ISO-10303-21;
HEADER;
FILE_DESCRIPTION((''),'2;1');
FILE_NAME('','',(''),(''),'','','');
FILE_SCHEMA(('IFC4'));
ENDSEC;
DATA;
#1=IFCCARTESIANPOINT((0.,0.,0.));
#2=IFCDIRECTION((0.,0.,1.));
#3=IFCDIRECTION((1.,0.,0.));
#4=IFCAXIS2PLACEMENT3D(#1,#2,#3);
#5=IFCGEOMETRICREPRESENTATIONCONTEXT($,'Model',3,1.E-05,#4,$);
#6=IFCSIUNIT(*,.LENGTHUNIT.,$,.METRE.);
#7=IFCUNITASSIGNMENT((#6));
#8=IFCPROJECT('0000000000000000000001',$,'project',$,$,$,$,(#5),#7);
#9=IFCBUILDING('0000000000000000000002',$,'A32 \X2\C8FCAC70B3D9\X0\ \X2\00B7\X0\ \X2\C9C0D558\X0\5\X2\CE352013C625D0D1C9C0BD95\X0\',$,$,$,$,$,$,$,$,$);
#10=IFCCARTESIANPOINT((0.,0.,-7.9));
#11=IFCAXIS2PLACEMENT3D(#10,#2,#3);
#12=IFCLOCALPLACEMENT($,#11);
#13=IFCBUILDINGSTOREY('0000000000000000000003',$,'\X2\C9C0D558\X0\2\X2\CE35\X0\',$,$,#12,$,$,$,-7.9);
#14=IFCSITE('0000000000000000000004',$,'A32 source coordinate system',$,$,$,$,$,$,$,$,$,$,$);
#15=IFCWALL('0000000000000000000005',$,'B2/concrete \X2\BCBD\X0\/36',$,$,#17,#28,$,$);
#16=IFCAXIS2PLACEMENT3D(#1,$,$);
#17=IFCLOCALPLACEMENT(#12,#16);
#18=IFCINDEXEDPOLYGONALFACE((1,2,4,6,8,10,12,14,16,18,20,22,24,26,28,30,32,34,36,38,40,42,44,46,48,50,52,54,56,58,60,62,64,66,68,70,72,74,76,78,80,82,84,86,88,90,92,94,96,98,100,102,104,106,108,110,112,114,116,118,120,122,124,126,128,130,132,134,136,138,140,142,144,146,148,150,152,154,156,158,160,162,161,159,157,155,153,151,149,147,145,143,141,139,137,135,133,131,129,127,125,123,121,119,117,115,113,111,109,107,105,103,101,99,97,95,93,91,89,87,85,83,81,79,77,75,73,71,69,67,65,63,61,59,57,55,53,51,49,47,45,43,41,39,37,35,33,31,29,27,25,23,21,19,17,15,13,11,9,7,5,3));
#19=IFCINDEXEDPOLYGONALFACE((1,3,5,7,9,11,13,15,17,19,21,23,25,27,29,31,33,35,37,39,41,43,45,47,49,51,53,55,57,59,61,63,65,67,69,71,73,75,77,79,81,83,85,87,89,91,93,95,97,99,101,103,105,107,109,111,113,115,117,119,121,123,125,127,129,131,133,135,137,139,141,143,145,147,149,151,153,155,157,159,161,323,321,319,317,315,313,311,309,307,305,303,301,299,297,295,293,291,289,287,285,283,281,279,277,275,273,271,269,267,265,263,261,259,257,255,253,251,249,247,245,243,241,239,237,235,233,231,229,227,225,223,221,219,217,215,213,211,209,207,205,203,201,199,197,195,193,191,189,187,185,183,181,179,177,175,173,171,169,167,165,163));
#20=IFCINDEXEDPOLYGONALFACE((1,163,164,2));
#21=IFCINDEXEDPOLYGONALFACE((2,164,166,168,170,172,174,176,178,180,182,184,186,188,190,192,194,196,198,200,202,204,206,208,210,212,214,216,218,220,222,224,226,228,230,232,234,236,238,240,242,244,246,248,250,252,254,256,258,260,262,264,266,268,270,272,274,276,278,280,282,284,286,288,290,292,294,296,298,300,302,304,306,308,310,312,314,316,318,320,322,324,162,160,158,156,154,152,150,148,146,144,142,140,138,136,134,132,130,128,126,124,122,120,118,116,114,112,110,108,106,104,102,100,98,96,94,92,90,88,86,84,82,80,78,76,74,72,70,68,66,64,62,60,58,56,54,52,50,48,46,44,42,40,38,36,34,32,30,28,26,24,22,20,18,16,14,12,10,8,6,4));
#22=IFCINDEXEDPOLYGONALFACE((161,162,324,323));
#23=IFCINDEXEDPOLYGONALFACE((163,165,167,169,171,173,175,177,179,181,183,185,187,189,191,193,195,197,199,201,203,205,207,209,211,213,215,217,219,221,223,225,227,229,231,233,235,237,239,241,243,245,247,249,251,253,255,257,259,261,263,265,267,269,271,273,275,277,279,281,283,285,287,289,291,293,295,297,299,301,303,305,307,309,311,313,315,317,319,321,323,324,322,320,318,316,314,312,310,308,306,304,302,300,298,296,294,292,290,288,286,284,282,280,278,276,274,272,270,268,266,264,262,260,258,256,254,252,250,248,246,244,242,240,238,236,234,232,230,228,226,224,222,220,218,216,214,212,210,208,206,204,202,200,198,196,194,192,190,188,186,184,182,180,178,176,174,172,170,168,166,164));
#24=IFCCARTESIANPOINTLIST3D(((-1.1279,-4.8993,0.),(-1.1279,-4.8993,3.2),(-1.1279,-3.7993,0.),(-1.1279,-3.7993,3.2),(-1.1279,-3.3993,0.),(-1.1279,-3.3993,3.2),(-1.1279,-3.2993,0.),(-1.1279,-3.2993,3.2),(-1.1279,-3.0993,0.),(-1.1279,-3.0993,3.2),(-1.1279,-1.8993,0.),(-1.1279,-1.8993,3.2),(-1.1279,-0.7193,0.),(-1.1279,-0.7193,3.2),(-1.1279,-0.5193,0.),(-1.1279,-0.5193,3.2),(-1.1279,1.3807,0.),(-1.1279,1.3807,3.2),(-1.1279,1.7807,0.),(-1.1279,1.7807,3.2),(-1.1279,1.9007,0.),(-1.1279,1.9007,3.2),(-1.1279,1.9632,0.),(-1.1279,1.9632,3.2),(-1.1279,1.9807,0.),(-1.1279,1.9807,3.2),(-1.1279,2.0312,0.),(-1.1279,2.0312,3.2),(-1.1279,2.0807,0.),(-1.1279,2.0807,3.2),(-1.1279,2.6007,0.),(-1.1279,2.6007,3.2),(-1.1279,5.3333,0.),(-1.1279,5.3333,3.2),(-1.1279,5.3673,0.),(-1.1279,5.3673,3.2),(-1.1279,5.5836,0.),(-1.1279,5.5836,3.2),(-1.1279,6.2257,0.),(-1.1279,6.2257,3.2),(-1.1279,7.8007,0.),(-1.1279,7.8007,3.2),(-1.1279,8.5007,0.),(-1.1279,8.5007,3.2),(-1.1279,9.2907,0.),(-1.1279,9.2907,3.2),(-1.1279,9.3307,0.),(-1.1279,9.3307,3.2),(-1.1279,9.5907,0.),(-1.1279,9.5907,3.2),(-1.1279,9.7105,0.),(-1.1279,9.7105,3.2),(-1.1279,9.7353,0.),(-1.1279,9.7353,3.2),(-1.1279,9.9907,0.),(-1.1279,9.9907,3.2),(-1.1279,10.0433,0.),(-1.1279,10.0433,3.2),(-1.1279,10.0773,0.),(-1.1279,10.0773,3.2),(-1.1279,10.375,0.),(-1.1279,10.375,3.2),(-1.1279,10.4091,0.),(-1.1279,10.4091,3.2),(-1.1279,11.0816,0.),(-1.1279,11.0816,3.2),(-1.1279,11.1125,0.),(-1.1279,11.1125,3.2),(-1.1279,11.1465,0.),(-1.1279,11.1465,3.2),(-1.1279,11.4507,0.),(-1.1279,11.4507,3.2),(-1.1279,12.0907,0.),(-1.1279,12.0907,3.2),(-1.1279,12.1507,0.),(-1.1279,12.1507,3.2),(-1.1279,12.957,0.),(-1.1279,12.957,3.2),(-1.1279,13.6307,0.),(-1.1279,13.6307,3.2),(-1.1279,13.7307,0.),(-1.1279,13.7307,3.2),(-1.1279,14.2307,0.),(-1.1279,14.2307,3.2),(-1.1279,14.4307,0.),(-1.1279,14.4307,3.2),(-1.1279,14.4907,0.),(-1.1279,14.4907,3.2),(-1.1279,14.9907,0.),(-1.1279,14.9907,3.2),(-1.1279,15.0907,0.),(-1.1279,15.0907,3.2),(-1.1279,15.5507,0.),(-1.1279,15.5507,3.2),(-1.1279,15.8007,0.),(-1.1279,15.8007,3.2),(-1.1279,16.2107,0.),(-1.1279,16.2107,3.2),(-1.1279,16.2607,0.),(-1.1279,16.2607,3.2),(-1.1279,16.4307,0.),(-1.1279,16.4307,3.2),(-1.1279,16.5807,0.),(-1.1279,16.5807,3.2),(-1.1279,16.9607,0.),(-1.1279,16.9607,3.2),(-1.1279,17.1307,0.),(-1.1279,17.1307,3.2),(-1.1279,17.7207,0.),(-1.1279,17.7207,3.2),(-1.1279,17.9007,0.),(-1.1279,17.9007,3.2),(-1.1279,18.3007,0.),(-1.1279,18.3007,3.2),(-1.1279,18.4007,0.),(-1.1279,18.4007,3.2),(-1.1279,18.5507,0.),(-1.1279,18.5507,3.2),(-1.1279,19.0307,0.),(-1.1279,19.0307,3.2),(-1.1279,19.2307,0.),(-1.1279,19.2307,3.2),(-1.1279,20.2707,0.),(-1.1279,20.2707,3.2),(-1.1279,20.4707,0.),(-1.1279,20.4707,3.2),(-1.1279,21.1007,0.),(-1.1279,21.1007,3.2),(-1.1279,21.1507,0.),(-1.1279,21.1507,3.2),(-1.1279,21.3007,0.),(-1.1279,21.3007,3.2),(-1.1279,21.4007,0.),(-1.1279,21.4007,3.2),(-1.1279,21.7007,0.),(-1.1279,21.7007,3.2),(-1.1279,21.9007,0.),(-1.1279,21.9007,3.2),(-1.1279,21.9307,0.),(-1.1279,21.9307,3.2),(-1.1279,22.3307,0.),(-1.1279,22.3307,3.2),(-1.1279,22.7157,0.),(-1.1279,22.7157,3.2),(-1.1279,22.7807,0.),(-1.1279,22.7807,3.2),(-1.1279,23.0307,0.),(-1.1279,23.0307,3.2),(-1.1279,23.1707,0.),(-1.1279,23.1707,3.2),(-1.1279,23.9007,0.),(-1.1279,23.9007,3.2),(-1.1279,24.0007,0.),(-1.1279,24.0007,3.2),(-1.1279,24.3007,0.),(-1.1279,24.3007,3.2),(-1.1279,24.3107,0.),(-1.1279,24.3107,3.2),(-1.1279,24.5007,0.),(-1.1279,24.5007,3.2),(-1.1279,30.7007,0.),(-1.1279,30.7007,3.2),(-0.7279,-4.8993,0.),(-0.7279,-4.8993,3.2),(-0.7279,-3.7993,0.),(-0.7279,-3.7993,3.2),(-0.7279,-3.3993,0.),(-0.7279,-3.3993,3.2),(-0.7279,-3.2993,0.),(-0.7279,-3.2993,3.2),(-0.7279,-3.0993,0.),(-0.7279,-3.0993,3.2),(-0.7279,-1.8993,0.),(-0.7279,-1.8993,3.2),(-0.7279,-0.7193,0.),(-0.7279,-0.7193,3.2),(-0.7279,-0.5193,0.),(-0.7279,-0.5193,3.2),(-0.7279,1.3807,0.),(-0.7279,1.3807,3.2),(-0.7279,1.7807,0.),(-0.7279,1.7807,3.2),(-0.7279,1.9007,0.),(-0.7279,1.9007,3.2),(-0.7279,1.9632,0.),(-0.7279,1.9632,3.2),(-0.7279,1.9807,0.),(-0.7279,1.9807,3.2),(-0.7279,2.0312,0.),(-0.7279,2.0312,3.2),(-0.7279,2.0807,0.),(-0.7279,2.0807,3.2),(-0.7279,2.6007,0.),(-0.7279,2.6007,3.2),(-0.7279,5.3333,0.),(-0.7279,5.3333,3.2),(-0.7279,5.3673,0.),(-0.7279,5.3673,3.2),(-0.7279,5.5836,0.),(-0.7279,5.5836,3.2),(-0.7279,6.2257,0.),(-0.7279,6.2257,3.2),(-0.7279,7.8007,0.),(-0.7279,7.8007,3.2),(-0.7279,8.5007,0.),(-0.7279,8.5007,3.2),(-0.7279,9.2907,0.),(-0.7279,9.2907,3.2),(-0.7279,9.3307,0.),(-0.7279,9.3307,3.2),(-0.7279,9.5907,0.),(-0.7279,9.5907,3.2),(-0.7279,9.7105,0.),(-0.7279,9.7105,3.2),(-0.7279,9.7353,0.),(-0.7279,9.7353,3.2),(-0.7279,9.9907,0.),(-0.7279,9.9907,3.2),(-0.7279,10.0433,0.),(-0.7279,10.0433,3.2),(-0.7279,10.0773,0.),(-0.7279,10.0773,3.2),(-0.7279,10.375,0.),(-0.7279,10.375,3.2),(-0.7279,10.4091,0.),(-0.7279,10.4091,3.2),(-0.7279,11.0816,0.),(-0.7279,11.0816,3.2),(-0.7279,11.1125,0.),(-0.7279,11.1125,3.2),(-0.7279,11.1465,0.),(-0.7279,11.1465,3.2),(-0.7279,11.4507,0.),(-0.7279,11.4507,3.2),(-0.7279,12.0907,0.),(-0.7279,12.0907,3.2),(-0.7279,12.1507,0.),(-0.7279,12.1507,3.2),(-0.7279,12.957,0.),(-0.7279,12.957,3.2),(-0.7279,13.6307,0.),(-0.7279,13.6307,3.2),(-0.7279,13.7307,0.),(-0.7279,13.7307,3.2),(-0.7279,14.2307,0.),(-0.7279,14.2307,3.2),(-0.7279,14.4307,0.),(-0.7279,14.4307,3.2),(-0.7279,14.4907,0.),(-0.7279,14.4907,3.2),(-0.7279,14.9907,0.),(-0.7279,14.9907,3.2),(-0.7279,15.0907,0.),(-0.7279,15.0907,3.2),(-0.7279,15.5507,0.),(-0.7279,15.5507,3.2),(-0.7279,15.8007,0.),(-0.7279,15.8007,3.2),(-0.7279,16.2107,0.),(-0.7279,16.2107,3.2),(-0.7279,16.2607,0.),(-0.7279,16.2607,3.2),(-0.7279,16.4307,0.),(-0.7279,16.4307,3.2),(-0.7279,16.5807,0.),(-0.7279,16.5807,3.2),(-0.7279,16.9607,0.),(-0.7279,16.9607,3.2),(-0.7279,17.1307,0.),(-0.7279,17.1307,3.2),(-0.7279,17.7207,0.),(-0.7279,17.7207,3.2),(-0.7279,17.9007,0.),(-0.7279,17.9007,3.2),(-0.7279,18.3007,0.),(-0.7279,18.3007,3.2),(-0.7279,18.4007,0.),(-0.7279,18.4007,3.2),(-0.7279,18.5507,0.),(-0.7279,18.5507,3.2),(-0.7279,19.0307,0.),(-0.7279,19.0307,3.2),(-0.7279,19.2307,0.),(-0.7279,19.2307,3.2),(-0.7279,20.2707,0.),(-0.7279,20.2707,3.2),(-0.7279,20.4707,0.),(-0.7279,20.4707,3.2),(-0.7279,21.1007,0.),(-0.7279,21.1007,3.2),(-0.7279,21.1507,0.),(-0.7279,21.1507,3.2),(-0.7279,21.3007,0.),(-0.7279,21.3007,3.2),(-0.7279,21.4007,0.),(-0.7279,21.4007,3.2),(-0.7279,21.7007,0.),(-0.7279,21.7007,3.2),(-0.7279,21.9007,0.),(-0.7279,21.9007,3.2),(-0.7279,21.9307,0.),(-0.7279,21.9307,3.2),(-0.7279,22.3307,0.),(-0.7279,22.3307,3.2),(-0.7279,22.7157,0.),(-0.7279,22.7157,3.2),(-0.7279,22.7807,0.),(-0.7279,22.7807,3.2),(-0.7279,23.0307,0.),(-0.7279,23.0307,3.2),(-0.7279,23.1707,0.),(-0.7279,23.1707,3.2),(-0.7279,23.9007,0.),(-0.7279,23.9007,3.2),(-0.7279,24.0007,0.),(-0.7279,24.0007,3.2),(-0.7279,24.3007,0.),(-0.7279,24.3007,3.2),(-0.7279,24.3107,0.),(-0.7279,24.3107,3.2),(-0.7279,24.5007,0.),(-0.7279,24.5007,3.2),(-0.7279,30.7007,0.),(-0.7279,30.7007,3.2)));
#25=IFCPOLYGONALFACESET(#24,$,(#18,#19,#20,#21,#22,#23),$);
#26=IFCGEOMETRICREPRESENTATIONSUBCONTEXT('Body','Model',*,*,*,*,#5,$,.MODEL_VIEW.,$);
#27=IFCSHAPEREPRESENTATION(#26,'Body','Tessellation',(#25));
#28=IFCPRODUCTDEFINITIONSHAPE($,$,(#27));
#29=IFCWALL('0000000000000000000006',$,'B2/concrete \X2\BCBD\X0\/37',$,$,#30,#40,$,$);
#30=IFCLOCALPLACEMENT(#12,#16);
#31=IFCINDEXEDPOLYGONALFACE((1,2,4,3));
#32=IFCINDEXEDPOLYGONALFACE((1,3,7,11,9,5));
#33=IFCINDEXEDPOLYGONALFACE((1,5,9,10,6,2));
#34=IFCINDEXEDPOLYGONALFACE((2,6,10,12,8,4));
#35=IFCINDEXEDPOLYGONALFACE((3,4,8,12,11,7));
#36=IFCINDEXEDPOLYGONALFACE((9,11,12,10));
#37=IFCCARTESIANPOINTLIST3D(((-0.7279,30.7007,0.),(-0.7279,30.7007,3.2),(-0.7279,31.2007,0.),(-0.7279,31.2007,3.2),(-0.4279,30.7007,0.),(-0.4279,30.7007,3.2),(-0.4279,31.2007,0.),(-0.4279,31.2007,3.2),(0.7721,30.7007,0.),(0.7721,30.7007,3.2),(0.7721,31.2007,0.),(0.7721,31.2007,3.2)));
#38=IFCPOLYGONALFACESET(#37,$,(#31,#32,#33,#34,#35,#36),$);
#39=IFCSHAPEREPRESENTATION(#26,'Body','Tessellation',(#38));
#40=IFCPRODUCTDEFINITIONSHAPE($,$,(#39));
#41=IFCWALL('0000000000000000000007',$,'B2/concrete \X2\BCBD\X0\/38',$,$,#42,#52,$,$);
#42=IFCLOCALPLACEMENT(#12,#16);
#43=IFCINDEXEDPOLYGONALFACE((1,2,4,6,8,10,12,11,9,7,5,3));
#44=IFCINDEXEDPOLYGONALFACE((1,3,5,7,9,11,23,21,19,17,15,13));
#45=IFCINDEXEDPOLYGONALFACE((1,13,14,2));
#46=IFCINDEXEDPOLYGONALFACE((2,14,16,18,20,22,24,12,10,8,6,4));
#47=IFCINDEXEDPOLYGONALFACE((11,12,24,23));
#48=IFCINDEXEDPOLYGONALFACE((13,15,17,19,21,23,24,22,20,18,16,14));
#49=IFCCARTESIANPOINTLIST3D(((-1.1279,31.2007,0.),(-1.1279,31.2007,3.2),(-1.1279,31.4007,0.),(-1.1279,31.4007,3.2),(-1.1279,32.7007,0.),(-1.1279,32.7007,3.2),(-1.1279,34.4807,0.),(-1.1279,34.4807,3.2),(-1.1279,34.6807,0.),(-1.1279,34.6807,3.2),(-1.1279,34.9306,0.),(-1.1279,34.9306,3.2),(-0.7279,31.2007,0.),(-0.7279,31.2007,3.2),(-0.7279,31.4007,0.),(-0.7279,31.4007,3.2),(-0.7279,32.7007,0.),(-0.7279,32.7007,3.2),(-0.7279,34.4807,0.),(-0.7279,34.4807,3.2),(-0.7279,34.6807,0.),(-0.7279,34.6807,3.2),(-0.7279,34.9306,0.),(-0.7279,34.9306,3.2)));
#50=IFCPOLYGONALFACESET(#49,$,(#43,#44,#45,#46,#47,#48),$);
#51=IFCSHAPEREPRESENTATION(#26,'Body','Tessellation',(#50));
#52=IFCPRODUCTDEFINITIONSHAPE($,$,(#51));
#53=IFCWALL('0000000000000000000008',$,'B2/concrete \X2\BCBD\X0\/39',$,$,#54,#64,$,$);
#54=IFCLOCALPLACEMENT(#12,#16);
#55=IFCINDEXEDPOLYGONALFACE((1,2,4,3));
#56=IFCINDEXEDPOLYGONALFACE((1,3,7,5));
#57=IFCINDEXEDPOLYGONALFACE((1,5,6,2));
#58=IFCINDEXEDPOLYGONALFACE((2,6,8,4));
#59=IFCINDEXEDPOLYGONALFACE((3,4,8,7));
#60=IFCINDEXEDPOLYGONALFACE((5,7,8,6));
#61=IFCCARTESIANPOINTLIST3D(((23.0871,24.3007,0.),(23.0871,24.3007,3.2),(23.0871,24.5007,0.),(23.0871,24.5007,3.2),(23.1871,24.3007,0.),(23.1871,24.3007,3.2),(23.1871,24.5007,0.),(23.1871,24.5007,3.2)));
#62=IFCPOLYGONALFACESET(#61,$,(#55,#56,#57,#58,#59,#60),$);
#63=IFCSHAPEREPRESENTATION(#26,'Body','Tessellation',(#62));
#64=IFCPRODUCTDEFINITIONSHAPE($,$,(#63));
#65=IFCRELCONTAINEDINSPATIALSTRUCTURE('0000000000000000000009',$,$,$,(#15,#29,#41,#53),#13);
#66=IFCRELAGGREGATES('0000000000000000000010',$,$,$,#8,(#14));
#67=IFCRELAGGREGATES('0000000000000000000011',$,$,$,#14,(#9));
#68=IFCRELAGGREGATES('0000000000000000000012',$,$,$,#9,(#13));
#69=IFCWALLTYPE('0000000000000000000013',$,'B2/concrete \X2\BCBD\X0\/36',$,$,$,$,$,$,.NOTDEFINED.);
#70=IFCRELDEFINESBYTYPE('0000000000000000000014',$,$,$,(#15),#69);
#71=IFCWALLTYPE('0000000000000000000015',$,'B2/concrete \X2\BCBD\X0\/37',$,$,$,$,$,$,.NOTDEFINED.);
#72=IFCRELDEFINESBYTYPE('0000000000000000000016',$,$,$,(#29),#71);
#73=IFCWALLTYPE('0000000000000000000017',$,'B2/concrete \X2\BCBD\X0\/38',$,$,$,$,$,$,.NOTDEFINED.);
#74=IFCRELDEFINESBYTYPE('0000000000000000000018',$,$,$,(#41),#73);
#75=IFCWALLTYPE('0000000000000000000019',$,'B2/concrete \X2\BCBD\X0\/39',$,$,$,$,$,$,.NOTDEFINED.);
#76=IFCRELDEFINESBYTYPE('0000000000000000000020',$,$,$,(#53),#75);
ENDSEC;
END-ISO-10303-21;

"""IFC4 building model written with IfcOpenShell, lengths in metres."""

from ifc_helpers import new_model, si_unit, frame, origin, origin_with_axes, place, context, subcontext, project, spatial, polyline, outline, extrude, source, transform, mapped, type_object, type_shapes, element, save


model = new_model("IFC4")

# Units and contexts
model_context = context("Model", 3, precision=1e-05, world=origin_with_axes())
body_context = subcontext(model_context, "Body", "Model", "MODEL_VIEW")
ifc_project = project(units=[si_unit("LENGTHUNIT", "METRE")], contexts=[model_context])

# Site, building, storey
site = spatial("IfcSite", under=ifc_project, Name="A32 source coordinate system")
building = spatial("IfcBuilding", under=site, Name="A32 주거동 · 지하5층–옥탑지붕")
storey_placement = place(None, frame((0.0, 0.0, -7.9), z_axis=(0.0, 0.0, 1.0), x_axis=(1.0, 0.0, 0.0)))
storey = spatial("IfcBuildingStorey", under=building, at=storey_placement, Name="지하2층", Elevation=-7.9)

# Walls
wall_type_1 = type_object("IfcWallType", Name="B2/concrete 벽/36", PredefinedType="NOTDEFINED")
shared_shape_1 = source(origin(), body_context, "Body", "SweptSolid", [
    extrude(outline(polyline([(-1.1279, -3.3993), (-1.1279, -3.2993), (-1.1279, -3.0993), (-1.1279, -1.8993), (-1.1279, -0.7193), (-1.1279, -0.5193), (-1.1279, 1.3807), (-1.1279, 1.7807), (-1.1279, 1.9007), (-1.1279, 1.9632), (-1.1279, 1.9807), (-1.1279, 2.0312), (-1.1279, 2.0807), (-1.1279, 2.6007), (-1.1279, 5.3333), (-1.1279, 5.3673), (-1.1279, 5.5836), (-1.1279, 6.2257), (-1.1279, 7.8007), (-1.1279, 8.5007), (-1.1279, 9.2907), (-1.1279, 9.3307), (-1.1279, 9.5907), (-1.1279, 9.7105), (-1.1279, 9.7353), (-1.1279, 9.9907), (-1.1279, 10.0433), (-1.1279, 10.0773), (-1.1279, 10.375), (-1.1279, 10.4091), (-1.1279, 11.0816), (-1.1279, 11.1125), (-1.1279, 11.1465), (-1.1279, 11.4507), (-1.1279, 12.0907), (-1.1279, 12.1507), (-1.1279, 12.957), (-1.1279, 13.6307), (-1.1279, 13.7307), (-1.1279, 14.2307), (-1.1279, 14.4307), (-1.1279, 14.4907), (-1.1279, 14.9907), (-1.1279, 15.0907), (-1.1279, 15.5507), (-1.1279, 15.8007), (-1.1279, 16.2107), (-1.1279, 16.2607), (-1.1279, 16.4307), (-1.1279, 16.5807), (-1.1279, 16.9607), (-1.1279, 17.1307), (-1.1279, 17.7207), (-1.1279, 17.9007), (-1.1279, 18.3007), (-1.1279, 18.4007), (-1.1279, 18.5507), (-1.1279, 19.0307), (-1.1279, 19.2307), (-1.1279, 20.2707), (-1.1279, 20.4707), (-1.1279, 21.1007), (-1.1279, 21.1507), (-1.1279, 21.3007), (-1.1279, 21.4007), (-1.1279, 21.7007), (-1.1279, 21.9007), (-1.1279, 21.9307), (-1.1279, 22.3307), (-1.1279, 22.7157), (-1.1279, 22.7807), (-1.1279, 23.0307), (-1.1279, 23.1707), (-1.1279, 23.9007), (-1.1279, 24.0007), (-1.1279, 24.3007), (-1.1279, 24.3107), (-1.1279, 24.5007), (-1.1279, 30.7007), (-0.7279, 30.7007), (-0.7279, 24.5007), (-0.7279, 24.3107), (-0.7279, 24.3007), (-0.7279, 24.0007), (-0.7279, 23.9007), (-0.7279, 23.1707), (-0.7279, 23.0307), (-0.7279, 22.7807), (-0.7279, 22.7157), (-0.7279, 22.3307), (-0.7279, 21.9307), (-0.7279, 21.9007), (-0.7279, 21.7007), (-0.7279, 21.4007), (-0.7279, 21.3007), (-0.7279, 21.1507), (-0.7279, 21.1007), (-0.7279, 20.4707), (-0.7279, 20.2707), (-0.7279, 19.2307), (-0.7279, 19.0307), (-0.7279, 18.5507), (-0.7279, 18.4007), (-0.7279, 18.3007), (-0.7279, 17.9007), (-0.7279, 17.7207), (-0.7279, 17.1307), (-0.7279, 16.9607), (-0.7279, 16.5807), (-0.7279, 16.4307), (-0.7279, 16.2607), (-0.7279, 16.2107), (-0.7279, 15.8007), (-0.7279, 15.5507), (-0.7279, 15.0907), (-0.7279, 14.9907), (-0.7279, 14.4907), (-0.7279, 14.4307), (-0.7279, 14.2307), (-0.7279, 13.7307), (-0.7279, 13.6307), (-0.7279, 12.957), (-0.7279, 12.1507), (-0.7279, 12.0907), (-0.7279, 11.4507), (-0.7279, 11.1465), (-0.7279, 11.1125), (-0.7279, 11.0816), (-0.7279, 10.4091), (-0.7279, 10.375), (-0.7279, 10.0773), (-0.7279, 10.0433), (-0.7279, 9.9907), (-0.7279, 9.7353), (-0.7279, 9.7105), (-0.7279, 9.5907), (-0.7279, 9.3307), (-0.7279, 9.2907), (-0.7279, 8.5007), (-0.7279, 7.8007), (-0.7279, 6.2257), (-0.7279, 5.5836), (-0.7279, 5.3673), (-0.7279, 5.3333), (-0.7279, 2.6007), (-0.7279, 2.0807), (-0.7279, 2.0312), (-0.7279, 1.9807), (-0.7279, 1.9632), (-0.7279, 1.9007), (-0.7279, 1.7807), (-0.7279, 1.3807), (-0.7279, -0.5193), (-0.7279, -0.7193), (-0.7279, -1.8993), (-0.7279, -3.0993), (-0.7279, -3.2993), (-0.7279, -3.3993), (-0.7279, -3.7993), (-0.7279, -4.8993), (-1.1279, -4.8993), (-1.1279, -3.7993), (-1.1279, -3.3993)])), origin(), (0.0, 0.0, 1.0), 3.2),
])
type_shapes(wall_type_1, [shared_shape_1])
wall_1_placement = place(storey_placement, origin_with_axes())
element("IfcWall", 1, at=wall_1_placement, inside=storey, type_object=wall_type_1, Name="B2/concrete 벽/36", context=body_context, shape_type="MappedRepresentation", body=[
    mapped(shared_shape_1, transform((0.0, 0.0, 0.0), scale=1.0)),
])
wall_type_2 = type_object("IfcWallType", Name="B2/concrete 벽/37", PredefinedType="NOTDEFINED")
shared_shape_2 = source(origin(), body_context, "Body", "SweptSolid", [
    extrude(outline(polyline([(0.7721, 31.2007), (0.7721, 30.7007), (-0.4279, 30.7007), (-0.7279, 30.7007), (-0.7279, 31.2007), (-0.4279, 31.2007), (0.7721, 31.2007)])), origin(), (0.0, 0.0, 1.0), 3.2),
])
type_shapes(wall_type_2, [shared_shape_2])
wall_2_placement = place(storey_placement, origin_with_axes())
element("IfcWall", 2, at=wall_2_placement, inside=storey, type_object=wall_type_2, Name="B2/concrete 벽/37", context=body_context, shape_type="MappedRepresentation", body=[
    mapped(shared_shape_2, transform((0.0, 0.0, 0.0), scale=1.0)),
])
wall_type_3 = type_object("IfcWallType", Name="B2/concrete 벽/38", PredefinedType="NOTDEFINED")
shared_shape_3 = source(origin(), body_context, "Body", "SweptSolid", [
    extrude(outline(polyline([(-1.1279, 32.7007), (-1.1279, 34.4807), (-1.1279, 34.6807), (-1.1279, 34.9306), (-0.7279, 34.9306), (-0.7279, 34.9306), (-0.7279, 34.6807), (-0.7279, 34.4807), (-0.7279, 32.7007), (-0.7279, 31.4007), (-0.7279, 31.2007), (-1.1279, 31.2007), (-1.1279, 31.4007), (-1.1279, 32.7007)])), origin(), (0.0, 0.0, 1.0), 3.2),
])
type_shapes(wall_type_3, [shared_shape_3])
wall_3_placement = place(storey_placement, origin_with_axes())
element("IfcWall", 3, at=wall_3_placement, inside=storey, type_object=wall_type_3, Name="B2/concrete 벽/38", context=body_context, shape_type="MappedRepresentation", body=[
    mapped(shared_shape_3, transform((0.0, 0.0, 0.0), scale=1.0)),
])
wall_type_4 = type_object("IfcWallType", Name="B2/concrete 벽/39", PredefinedType="NOTDEFINED")
shared_shape_4 = source(origin(), body_context, "Body", "SweptSolid", [
    extrude(outline(polyline([(23.1871, 24.3007), (23.0871, 24.3007), (23.0871, 24.5007), (23.1871, 24.5007), (23.1871, 24.3007)])), origin(), (0.0, 0.0, 1.0), 3.2),
])
type_shapes(wall_type_4, [shared_shape_4])
wall_4_placement = place(storey_placement, origin_with_axes())
element("IfcWall", 4, at=wall_4_placement, inside=storey, type_object=wall_type_4, Name="B2/concrete 벽/39", context=body_context, shape_type="MappedRepresentation", body=[
    mapped(shared_shape_4, transform((0.0, 0.0, 0.0), scale=1.0)),
])

save(model, "model.ifc")
